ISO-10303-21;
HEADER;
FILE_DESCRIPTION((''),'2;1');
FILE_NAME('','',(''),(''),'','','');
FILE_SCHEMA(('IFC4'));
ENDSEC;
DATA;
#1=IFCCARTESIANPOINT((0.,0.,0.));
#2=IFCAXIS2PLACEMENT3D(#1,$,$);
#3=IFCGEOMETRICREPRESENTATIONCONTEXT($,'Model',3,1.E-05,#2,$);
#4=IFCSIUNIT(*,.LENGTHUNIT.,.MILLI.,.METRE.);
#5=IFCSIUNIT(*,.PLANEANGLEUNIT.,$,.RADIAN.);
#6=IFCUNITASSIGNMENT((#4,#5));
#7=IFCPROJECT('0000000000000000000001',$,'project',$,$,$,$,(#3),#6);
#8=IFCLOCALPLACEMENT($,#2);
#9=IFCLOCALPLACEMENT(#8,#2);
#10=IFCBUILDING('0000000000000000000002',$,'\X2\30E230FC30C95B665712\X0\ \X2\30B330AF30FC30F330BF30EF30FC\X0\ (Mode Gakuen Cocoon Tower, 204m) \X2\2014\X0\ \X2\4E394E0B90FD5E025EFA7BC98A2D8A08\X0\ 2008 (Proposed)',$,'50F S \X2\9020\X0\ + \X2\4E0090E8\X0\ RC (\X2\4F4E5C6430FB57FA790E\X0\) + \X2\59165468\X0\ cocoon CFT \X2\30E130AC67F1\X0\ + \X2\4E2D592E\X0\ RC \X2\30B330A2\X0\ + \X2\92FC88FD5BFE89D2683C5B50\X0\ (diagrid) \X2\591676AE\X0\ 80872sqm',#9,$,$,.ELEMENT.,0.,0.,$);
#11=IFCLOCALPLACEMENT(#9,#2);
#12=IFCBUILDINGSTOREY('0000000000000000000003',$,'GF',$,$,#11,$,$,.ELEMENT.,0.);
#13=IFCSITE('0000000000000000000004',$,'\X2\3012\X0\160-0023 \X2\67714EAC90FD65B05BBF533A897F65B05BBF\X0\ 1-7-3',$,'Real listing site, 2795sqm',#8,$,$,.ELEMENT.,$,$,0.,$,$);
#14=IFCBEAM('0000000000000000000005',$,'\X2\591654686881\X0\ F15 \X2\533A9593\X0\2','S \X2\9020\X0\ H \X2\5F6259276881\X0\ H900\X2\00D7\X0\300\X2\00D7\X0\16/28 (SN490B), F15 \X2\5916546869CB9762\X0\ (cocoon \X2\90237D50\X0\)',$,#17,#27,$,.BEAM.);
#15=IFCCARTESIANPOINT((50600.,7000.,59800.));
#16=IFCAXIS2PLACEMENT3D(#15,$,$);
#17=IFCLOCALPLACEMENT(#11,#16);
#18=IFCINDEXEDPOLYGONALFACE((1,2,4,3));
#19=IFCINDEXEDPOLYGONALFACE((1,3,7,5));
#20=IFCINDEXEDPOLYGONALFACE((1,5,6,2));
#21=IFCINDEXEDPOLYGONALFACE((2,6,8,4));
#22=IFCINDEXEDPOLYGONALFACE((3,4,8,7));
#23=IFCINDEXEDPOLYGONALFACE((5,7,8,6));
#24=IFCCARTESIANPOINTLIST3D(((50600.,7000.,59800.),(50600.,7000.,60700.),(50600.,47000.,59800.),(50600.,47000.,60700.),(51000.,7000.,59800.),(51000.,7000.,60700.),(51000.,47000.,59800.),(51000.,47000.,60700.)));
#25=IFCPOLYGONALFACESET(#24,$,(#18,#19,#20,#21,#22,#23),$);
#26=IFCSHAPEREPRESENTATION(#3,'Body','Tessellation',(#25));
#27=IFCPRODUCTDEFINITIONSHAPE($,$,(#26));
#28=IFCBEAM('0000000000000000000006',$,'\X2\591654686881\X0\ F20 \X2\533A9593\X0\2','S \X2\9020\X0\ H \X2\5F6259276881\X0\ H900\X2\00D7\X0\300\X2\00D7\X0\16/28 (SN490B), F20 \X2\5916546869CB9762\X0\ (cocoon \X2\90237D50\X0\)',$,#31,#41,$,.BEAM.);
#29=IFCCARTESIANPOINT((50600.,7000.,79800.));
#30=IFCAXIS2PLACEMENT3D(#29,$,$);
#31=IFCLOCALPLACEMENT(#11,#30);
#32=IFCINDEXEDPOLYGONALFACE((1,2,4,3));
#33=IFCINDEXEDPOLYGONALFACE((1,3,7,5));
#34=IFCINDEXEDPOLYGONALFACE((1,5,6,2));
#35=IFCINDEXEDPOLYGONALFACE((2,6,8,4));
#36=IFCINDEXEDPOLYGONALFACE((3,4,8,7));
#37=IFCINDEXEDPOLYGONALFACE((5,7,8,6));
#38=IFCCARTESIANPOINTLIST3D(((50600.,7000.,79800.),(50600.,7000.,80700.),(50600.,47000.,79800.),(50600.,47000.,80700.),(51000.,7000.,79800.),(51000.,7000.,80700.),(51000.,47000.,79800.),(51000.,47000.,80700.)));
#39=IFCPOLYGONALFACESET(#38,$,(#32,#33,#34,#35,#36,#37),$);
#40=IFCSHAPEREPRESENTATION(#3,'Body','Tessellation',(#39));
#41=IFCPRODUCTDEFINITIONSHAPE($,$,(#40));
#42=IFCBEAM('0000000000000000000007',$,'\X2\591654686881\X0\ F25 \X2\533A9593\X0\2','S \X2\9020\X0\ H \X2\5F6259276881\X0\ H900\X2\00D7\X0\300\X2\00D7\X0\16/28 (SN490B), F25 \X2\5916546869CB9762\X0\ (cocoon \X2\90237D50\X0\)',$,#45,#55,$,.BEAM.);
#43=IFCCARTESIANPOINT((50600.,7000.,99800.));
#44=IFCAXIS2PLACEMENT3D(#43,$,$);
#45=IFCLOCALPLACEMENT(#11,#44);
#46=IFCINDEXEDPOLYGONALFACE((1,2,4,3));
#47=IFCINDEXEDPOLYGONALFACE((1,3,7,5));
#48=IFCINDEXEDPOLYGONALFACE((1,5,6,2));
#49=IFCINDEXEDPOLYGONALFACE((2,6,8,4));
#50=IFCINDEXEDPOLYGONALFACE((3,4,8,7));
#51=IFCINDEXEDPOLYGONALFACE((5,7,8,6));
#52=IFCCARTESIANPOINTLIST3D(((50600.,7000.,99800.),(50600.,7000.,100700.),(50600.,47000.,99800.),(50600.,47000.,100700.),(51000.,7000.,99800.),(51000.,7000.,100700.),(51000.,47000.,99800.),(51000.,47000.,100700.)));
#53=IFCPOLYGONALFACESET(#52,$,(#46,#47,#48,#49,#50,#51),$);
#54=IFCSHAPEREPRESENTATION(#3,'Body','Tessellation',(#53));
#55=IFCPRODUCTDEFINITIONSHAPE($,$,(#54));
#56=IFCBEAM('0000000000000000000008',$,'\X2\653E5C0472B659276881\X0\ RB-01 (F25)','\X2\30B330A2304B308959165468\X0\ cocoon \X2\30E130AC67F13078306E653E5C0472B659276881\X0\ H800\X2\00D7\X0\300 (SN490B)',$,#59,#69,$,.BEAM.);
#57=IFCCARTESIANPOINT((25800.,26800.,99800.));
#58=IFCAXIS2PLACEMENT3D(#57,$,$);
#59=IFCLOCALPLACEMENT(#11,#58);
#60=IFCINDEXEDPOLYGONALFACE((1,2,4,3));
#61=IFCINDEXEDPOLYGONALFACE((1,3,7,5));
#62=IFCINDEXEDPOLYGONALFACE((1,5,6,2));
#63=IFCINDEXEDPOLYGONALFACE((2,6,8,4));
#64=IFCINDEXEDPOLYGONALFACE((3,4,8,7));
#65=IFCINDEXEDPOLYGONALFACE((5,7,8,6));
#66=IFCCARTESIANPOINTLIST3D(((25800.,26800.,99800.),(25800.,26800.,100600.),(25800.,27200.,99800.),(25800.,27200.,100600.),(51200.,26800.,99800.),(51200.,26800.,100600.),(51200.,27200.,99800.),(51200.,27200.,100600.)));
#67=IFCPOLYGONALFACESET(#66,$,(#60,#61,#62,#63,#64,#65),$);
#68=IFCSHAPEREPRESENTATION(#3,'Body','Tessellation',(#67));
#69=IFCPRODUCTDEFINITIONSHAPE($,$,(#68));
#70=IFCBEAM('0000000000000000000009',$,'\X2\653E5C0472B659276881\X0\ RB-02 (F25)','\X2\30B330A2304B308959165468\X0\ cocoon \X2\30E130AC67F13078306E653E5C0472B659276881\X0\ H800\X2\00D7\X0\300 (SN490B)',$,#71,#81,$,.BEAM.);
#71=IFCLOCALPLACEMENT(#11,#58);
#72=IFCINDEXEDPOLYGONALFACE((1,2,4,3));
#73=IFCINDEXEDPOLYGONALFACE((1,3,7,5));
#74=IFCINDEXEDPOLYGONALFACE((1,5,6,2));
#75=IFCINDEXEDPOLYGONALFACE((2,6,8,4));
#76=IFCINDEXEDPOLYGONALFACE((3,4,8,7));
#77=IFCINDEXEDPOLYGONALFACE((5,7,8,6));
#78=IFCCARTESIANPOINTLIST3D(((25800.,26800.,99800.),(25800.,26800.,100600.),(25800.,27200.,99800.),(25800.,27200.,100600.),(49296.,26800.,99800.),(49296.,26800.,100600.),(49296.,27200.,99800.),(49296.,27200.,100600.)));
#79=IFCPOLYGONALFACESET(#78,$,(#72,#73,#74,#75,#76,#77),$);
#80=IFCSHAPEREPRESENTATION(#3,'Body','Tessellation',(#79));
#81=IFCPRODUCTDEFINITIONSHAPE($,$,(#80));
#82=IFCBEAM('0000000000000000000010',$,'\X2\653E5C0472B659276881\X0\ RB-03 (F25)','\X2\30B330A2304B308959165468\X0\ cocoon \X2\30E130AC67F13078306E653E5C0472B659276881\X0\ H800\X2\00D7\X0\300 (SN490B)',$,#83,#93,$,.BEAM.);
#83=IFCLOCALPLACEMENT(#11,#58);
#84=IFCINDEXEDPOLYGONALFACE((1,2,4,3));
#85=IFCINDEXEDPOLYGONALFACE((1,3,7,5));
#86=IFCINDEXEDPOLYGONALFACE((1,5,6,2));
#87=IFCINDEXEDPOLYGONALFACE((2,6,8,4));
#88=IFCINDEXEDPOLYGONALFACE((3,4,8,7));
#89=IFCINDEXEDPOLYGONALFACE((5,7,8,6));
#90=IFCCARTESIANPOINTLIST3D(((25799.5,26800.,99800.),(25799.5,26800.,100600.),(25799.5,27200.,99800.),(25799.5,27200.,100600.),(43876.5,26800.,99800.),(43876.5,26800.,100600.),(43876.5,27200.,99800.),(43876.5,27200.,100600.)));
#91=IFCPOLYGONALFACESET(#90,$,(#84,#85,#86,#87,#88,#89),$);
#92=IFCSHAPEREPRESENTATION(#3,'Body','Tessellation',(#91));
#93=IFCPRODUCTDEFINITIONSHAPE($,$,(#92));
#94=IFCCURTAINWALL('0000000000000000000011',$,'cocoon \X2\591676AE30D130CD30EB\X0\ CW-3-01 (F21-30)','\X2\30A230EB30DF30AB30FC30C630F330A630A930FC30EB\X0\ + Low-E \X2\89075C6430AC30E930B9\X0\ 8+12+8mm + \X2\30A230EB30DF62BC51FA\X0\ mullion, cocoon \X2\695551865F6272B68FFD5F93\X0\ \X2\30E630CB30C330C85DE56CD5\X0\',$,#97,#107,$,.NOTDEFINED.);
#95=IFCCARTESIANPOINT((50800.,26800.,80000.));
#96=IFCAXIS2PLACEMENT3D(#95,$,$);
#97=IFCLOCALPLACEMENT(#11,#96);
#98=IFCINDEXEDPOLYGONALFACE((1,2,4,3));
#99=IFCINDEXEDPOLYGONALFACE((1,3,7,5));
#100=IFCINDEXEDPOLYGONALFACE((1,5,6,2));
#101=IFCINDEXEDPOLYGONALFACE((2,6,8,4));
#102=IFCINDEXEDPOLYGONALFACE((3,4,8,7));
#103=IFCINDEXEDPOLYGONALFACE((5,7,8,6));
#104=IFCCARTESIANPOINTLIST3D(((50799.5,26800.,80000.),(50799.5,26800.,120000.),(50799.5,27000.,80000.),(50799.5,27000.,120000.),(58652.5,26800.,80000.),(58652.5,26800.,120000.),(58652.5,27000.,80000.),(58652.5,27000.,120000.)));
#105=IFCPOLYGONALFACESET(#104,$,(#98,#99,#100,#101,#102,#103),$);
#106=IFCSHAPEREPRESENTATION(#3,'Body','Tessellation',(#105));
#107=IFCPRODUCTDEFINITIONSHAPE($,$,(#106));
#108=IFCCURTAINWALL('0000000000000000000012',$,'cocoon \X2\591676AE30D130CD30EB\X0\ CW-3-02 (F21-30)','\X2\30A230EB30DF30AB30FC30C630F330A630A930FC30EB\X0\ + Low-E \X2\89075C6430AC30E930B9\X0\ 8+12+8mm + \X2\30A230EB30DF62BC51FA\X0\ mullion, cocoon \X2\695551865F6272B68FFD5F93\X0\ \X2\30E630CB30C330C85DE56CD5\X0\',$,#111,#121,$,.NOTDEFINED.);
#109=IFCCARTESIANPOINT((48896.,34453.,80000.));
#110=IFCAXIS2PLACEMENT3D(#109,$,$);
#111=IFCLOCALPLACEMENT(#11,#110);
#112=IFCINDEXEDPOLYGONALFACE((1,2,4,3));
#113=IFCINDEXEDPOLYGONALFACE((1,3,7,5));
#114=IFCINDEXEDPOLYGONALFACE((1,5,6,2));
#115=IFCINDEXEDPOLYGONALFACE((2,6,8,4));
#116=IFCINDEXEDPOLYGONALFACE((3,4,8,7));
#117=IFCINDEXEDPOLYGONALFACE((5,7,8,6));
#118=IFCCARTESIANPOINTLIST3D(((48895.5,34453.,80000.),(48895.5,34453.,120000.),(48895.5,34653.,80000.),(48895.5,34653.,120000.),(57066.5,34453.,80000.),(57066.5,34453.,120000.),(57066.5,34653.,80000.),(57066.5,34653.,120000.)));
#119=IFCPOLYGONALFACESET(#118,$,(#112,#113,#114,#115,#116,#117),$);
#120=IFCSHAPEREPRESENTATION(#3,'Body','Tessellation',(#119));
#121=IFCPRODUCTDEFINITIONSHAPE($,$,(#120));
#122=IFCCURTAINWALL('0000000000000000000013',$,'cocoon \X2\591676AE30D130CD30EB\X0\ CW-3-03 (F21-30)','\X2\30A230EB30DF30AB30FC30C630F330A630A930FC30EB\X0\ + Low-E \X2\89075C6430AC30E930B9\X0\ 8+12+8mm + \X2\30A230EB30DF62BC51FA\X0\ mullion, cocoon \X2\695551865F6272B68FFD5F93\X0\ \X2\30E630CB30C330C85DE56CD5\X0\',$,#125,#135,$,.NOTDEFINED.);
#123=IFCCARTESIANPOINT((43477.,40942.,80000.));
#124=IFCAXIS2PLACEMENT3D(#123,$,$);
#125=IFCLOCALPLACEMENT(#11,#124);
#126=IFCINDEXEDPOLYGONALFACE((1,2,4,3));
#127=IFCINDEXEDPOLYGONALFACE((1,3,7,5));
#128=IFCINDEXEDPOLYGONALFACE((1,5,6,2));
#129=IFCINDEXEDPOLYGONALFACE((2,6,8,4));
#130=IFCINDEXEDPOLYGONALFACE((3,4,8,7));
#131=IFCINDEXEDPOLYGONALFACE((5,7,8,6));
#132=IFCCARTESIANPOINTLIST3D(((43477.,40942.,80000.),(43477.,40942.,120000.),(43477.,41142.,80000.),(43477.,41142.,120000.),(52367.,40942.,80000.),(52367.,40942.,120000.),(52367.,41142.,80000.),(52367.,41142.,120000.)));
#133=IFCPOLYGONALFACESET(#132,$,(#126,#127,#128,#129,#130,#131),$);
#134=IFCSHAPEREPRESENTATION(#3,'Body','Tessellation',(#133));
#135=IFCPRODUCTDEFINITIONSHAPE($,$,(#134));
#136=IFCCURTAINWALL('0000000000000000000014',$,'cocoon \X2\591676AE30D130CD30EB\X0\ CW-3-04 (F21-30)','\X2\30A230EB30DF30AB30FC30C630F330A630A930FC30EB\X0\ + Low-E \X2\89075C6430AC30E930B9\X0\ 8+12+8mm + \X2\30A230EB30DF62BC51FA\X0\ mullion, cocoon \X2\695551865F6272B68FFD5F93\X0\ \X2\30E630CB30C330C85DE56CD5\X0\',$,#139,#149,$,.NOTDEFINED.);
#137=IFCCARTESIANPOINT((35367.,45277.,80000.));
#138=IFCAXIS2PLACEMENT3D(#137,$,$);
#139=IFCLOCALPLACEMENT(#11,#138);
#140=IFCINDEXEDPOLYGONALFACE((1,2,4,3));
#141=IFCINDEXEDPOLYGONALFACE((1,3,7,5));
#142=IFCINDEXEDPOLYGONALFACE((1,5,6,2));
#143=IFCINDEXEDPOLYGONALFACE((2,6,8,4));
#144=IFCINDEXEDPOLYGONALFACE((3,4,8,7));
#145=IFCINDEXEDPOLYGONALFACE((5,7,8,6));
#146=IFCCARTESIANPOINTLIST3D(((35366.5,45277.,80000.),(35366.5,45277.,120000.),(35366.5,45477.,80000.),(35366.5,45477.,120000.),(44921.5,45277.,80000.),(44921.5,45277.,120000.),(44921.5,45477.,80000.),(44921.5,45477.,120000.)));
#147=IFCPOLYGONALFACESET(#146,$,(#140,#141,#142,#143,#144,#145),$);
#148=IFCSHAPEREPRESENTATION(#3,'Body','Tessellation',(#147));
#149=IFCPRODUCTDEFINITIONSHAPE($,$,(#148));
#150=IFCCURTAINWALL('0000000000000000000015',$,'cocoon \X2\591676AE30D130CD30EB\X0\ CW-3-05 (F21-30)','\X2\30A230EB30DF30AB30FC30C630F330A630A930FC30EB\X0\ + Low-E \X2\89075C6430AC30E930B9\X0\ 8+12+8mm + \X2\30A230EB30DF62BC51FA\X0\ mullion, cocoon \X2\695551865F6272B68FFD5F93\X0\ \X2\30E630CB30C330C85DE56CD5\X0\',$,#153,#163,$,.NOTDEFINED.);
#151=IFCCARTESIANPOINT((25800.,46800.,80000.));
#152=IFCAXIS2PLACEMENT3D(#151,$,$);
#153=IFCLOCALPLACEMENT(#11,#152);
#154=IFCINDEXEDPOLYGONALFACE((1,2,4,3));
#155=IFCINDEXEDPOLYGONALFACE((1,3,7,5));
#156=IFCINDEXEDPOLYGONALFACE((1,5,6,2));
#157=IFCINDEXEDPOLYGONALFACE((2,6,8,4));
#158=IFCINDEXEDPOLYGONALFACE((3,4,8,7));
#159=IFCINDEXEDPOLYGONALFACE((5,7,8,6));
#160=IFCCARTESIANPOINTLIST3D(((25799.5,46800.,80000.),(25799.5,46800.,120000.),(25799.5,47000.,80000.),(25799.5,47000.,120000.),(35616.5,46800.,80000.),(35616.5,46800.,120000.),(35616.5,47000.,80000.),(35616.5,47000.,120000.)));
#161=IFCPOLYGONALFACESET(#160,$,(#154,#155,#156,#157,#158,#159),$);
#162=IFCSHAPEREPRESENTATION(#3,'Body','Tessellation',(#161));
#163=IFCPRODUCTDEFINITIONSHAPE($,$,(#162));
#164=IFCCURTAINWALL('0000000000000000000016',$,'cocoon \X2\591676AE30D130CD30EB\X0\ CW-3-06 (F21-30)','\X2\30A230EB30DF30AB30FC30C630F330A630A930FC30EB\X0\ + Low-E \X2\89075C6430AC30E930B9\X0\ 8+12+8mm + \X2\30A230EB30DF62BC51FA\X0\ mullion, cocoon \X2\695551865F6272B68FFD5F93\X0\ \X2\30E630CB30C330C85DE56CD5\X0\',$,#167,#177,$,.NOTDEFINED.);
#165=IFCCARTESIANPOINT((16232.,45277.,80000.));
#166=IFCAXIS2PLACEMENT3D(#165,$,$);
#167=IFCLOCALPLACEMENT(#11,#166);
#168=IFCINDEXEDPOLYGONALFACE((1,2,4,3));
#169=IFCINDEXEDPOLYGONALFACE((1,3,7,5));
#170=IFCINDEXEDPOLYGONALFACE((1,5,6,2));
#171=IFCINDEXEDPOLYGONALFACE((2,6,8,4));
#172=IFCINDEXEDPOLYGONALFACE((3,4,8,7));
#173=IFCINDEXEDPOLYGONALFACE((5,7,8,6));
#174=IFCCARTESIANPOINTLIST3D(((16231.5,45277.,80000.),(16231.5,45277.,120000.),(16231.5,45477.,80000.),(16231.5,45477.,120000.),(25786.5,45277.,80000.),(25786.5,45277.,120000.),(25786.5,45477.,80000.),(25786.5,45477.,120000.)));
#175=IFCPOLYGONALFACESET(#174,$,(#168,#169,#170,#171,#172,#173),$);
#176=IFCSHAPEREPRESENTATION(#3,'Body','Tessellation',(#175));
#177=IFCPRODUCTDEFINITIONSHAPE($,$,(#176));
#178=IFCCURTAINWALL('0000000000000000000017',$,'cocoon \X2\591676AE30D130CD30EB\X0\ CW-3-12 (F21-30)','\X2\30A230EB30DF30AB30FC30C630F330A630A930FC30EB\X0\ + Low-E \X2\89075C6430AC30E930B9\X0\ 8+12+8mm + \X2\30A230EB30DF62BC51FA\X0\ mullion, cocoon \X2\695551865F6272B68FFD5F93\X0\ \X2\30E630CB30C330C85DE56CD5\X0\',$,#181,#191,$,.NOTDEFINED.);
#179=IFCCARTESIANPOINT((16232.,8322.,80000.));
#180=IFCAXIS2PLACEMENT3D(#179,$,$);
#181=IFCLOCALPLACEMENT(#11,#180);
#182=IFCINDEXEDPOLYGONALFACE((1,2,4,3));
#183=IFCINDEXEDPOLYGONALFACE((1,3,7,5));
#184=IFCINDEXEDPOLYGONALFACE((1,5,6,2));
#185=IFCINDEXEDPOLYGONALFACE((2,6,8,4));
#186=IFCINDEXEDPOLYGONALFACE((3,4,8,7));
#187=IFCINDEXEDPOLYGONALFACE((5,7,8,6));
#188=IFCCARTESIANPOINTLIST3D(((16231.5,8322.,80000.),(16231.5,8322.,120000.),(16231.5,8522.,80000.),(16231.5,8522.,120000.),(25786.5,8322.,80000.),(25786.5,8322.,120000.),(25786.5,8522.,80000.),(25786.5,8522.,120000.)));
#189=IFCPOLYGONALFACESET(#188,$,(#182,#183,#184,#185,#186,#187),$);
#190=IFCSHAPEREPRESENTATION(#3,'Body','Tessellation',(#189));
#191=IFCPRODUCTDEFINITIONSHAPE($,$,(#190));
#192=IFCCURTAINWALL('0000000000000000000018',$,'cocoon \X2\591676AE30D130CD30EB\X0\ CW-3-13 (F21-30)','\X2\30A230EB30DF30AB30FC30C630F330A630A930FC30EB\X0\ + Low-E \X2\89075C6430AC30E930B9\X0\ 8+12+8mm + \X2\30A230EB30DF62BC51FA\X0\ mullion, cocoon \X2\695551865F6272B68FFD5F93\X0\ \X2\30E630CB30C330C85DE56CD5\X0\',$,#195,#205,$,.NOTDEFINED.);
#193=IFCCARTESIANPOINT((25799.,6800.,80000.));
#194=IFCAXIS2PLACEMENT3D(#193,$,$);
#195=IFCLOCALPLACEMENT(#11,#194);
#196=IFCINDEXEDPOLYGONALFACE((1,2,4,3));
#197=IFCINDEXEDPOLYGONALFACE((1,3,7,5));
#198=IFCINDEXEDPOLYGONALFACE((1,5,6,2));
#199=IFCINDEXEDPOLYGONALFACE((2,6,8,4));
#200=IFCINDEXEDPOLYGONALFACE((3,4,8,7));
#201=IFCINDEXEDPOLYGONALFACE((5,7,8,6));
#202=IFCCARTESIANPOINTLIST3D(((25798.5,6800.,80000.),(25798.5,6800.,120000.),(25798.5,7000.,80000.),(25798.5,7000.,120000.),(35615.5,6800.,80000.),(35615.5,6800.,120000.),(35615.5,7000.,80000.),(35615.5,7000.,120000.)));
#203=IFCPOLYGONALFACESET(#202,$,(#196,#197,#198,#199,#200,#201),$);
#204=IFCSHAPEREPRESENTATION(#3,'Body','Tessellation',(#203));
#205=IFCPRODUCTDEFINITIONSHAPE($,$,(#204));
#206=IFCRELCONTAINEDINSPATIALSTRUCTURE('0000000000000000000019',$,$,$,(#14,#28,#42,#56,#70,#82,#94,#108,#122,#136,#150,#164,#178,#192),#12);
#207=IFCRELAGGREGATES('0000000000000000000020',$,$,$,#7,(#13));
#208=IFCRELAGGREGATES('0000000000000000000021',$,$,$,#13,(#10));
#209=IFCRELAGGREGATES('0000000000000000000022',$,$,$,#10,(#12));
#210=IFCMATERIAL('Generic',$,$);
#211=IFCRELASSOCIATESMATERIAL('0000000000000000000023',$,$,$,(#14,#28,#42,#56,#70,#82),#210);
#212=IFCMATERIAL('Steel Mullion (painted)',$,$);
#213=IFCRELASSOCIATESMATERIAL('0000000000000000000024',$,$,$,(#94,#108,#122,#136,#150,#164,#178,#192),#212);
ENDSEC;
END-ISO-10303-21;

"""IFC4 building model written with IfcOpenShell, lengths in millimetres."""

from ifc_helpers import new_model, si_unit, frame, frame_2d, origin, place, context, project, spatial, rectangle, extrude, material, element, save


model = new_model("IFC4")

# Units and contexts
model_context = context("Model", 3, precision=1e-05, world=origin())
ifc_project = project(units=[si_unit("LENGTHUNIT", "METRE", prefix="MILLI"), si_unit("PLANEANGLEUNIT", "RADIAN")], contexts=[model_context])

# Site, building, storey
site_placement = place(None, origin())
site = spatial("IfcSite", under=ifc_project, at=site_placement, Name="〒160-0023 東京都新宿区西新宿 1-7-3", ObjectType="Real listing site, 2795sqm", CompositionType="ELEMENT", RefElevation=0.0)
building_placement = place(site_placement, origin())
building = spatial("IfcBuilding", under=site, at=building_placement, Name="モード学園 コクーンタワー (Mode Gakuen Cocoon Tower, 204m) — 丹下都市建築設計 2008 (Proposed)", ObjectType="50F S 造 + 一部 RC (低層・基礎) + 外周 cocoon CFT メガ柱 + 中央 RC コア + 鋼製対角格子 (diagrid) 外皮 80872sqm", CompositionType="ELEMENT", ElevationOfRefHeight=0.0, ElevationOfTerrain=0.0)
storey_placement = place(building_placement, origin())
storey = spatial("IfcBuildingStorey", under=building, at=storey_placement, Name="GF", CompositionType="ELEMENT", Elevation=0.0)

# Beams
ifc_material_1 = material(Name="Generic")
beam_1_placement = place(storey_placement, frame((50600.0, 7000.0, 59800.0)))
element("IfcBeam", 1, at=beam_1_placement, inside=storey, material=ifc_material_1, Name="外周梁 F15 区間2", Description="S 造 H 形大梁 H900×300×16/28 (SN490B), F15 外周構面 (cocoon 連結)", PredefinedType="BEAM", context=model_context, shape_type="SweptSolid", body=[
    extrude(rectangle(XDim=400.0, YDim=40000.0, at=frame_2d((200.0, 20000.0))), frame((50600.0, 7000.0, 59800.0)), (0.0, 0.0, 1.0), 900.0),
])
beam_2_placement = place(storey_placement, frame((50600.0, 7000.0, 79800.0)))
element("IfcBeam", 2, at=beam_2_placement, inside=storey, material=ifc_material_1, Name="外周梁 F20 区間2", Description="S 造 H 形大梁 H900×300×16/28 (SN490B), F20 外周構面 (cocoon 連結)", PredefinedType="BEAM", context=model_context, shape_type="SweptSolid", body=[
    extrude(rectangle(XDim=400.0, YDim=40000.0, at=frame_2d((200.0, 20000.0))), frame((50600.0, 7000.0, 79800.0)), (0.0, 0.0, 1.0), 900.0),
])
beam_3_placement = place(storey_placement, frame((50600.0, 7000.0, 99800.0)))
element("IfcBeam", 3, at=beam_3_placement, inside=storey, material=ifc_material_1, Name="外周梁 F25 区間2", Description="S 造 H 形大梁 H900×300×16/28 (SN490B), F25 外周構面 (cocoon 連結)", PredefinedType="BEAM", context=model_context, shape_type="SweptSolid", body=[
    extrude(rectangle(XDim=400.0, YDim=40000.0, at=frame_2d((200.0, 20000.0))), frame((50600.0, 7000.0, 99800.0)), (0.0, 0.0, 1.0), 900.0),
])
beam_4_placement = place(storey_placement, frame((25800.0, 26800.0, 99800.0)))
element("IfcBeam", 4, at=beam_4_placement, inside=storey, material=ifc_material_1, Name="放射状大梁 RB-01 (F25)", Description="コアから外周 cocoon メガ柱への放射状大梁 H800×300 (SN490B)", PredefinedType="BEAM", context=model_context, shape_type="SweptSolid", body=[
    extrude(rectangle(XDim=25400.0, YDim=400.0, at=frame_2d((12700.0, 200.0))), frame((25800.0, 26800.0, 99800.0)), (0.0, 0.0, 1.0), 800.0),
])
beam_5_placement = place(storey_placement, frame((25800.0, 26800.0, 99800.0)))
element("IfcBeam", 5, at=beam_5_placement, inside=storey, material=ifc_material_1, Name="放射状大梁 RB-02 (F25)", Description="コアから外周 cocoon メガ柱への放射状大梁 H800×300 (SN490B)", PredefinedType="BEAM", context=model_context, shape_type="SweptSolid", body=[
    extrude(rectangle(XDim=23496.0, YDim=400.0, at=frame_2d((11748.0, 200.0))), frame((25800.0, 26800.0, 99800.0)), (0.0, 0.0, 1.0), 800.0),
])
beam_6_placement = place(storey_placement, frame((25800.0, 26800.0, 99800.0)))
element("IfcBeam", 6, at=beam_6_placement, inside=storey, material=ifc_material_1, Name="放射状大梁 RB-03 (F25)", Description="コアから外周 cocoon メガ柱への放射状大梁 H800×300 (SN490B)", PredefinedType="BEAM", context=model_context, shape_type="SweptSolid", body=[
    extrude(rectangle(XDim=18077.0, YDim=400.0, at=frame_2d((9038.0, 200.0))), frame((25800.0, 26800.0, 99800.0)), (0.0, 0.0, 1.0), 800.0),
])

# Curtain walls
ifc_material_2 = material(Name="Steel Mullion (painted)")
curtain_wall_1_placement = place(storey_placement, frame((50800.0, 26800.0, 80000.0)))
element("IfcCurtainWall", 7, at=curtain_wall_1_placement, inside=storey, material=ifc_material_2, Name="cocoon 外皮パネル CW-3-01 (F21-30)", Description="アルミカーテンウォール + Low-E 複層ガラス 8+12+8mm + アルミ押出 mullion, cocoon 楕円形状追従 ユニット工法", PredefinedType="NOTDEFINED", context=model_context, shape_type="SweptSolid", body=[
    extrude(rectangle(XDim=7853.0, YDim=200.0, at=frame_2d((3926.0, 100.0))), frame((50800.0, 26800.0, 80000.0)), (0.0, 0.0, 1.0), 40000.0),
])
curtain_wall_2_placement = place(storey_placement, frame((48896.0, 34453.0, 80000.0)))
element("IfcCurtainWall", 8, at=curtain_wall_2_placement, inside=storey, material=ifc_material_2, Name="cocoon 外皮パネル CW-3-02 (F21-30)", Description="アルミカーテンウォール + Low-E 複層ガラス 8+12+8mm + アルミ押出 mullion, cocoon 楕円形状追従 ユニット工法", PredefinedType="NOTDEFINED", context=model_context, shape_type="SweptSolid", body=[
    extrude(rectangle(XDim=8171.0, YDim=200.0, at=frame_2d((4085.0, 100.0))), frame((48896.0, 34453.0, 80000.0)), (0.0, 0.0, 1.0), 40000.0),
])
curtain_wall_3_placement = place(storey_placement, frame((43477.0, 40942.0, 80000.0)))
element("IfcCurtainWall", 9, at=curtain_wall_3_placement, inside=storey, material=ifc_material_2, Name="cocoon 外皮パネル CW-3-03 (F21-30)", Description="アルミカーテンウォール + Low-E 複層ガラス 8+12+8mm + アルミ押出 mullion, cocoon 楕円形状追従 ユニット工法", PredefinedType="NOTDEFINED", context=model_context, shape_type="SweptSolid", body=[
    extrude(rectangle(XDim=8890.0, YDim=200.0, at=frame_2d((4445.0, 100.0))), frame((43477.0, 40942.0, 80000.0)), (0.0, 0.0, 1.0), 40000.0),
])
curtain_wall_4_placement = place(storey_placement, frame((35367.0, 45277.0, 80000.0)))
element("IfcCurtainWall", 10, at=curtain_wall_4_placement, inside=storey, material=ifc_material_2, Name="cocoon 外皮パネル CW-3-04 (F21-30)", Description="アルミカーテンウォール + Low-E 複層ガラス 8+12+8mm + アルミ押出 mullion, cocoon 楕円形状追従 ユニット工法", PredefinedType="NOTDEFINED", context=model_context, shape_type="SweptSolid", body=[
    extrude(rectangle(XDim=9555.0, YDim=200.0, at=frame_2d((4777.0, 100.0))), frame((35367.0, 45277.0, 80000.0)), (0.0, 0.0, 1.0), 40000.0),
])
curtain_wall_5_placement = place(storey_placement, frame((25800.0, 46800.0, 80000.0)))
element("IfcCurtainWall", 11, at=curtain_wall_5_placement, inside=storey, material=ifc_material_2, Name="cocoon 外皮パネル CW-3-05 (F21-30)", Description="アルミカーテンウォール + Low-E 複層ガラス 8+12+8mm + アルミ押出 mullion, cocoon 楕円形状追従 ユニット工法", PredefinedType="NOTDEFINED", context=model_context, shape_type="SweptSolid", body=[
    extrude(rectangle(XDim=9817.0, YDim=200.0, at=frame_2d((4908.0, 100.0))), frame((25800.0, 46800.0, 80000.0)), (0.0, 0.0, 1.0), 40000.0),
])
curtain_wall_6_placement = place(storey_placement, frame((16232.0, 45277.0, 80000.0)))
element("IfcCurtainWall", 12, at=curtain_wall_6_placement, inside=storey, material=ifc_material_2, Name="cocoon 外皮パネル CW-3-06 (F21-30)", Description="アルミカーテンウォール + Low-E 複層ガラス 8+12+8mm + アルミ押出 mullion, cocoon 楕円形状追従 ユニット工法", PredefinedType="NOTDEFINED", context=model_context, shape_type="SweptSolid", body=[
    extrude(rectangle(XDim=9555.0, YDim=200.0, at=frame_2d((4777.0, 100.0))), frame((16232.0, 45277.0, 80000.0)), (0.0, 0.0, 1.0), 40000.0),
])
curtain_wall_7_placement = place(storey_placement, frame((16232.0, 8322.0, 80000.0)))
element("IfcCurtainWall", 13, at=curtain_wall_7_placement, inside=storey, material=ifc_material_2, Name="cocoon 外皮パネル CW-3-12 (F21-30)", Description="アルミカーテンウォール + Low-E 複層ガラス 8+12+8mm + アルミ押出 mullion, cocoon 楕円形状追従 ユニット工法", PredefinedType="NOTDEFINED", context=model_context, shape_type="SweptSolid", body=[
    extrude(rectangle(XDim=9555.0, YDim=200.0, at=frame_2d((4777.0, 100.0))), frame((16232.0, 8322.0, 80000.0)), (0.0, 0.0, 1.0), 40000.0),
])
curtain_wall_8_placement = place(storey_placement, frame((25799.0, 6800.0, 80000.0)))
element("IfcCurtainWall", 14, at=curtain_wall_8_placement, inside=storey, material=ifc_material_2, Name="cocoon 外皮パネル CW-3-13 (F21-30)", Description="アルミカーテンウォール + Low-E 複層ガラス 8+12+8mm + アルミ押出 mullion, cocoon 楕円形状追従 ユニット工法", PredefinedType="NOTDEFINED", context=model_context, shape_type="SweptSolid", body=[
    extrude(rectangle(XDim=9817.0, YDim=200.0, at=frame_2d((4908.0, 100.0))), frame((25799.0, 6800.0, 80000.0)), (0.0, 0.0, 1.0), 40000.0),
])

save(model, "model.ifc")
